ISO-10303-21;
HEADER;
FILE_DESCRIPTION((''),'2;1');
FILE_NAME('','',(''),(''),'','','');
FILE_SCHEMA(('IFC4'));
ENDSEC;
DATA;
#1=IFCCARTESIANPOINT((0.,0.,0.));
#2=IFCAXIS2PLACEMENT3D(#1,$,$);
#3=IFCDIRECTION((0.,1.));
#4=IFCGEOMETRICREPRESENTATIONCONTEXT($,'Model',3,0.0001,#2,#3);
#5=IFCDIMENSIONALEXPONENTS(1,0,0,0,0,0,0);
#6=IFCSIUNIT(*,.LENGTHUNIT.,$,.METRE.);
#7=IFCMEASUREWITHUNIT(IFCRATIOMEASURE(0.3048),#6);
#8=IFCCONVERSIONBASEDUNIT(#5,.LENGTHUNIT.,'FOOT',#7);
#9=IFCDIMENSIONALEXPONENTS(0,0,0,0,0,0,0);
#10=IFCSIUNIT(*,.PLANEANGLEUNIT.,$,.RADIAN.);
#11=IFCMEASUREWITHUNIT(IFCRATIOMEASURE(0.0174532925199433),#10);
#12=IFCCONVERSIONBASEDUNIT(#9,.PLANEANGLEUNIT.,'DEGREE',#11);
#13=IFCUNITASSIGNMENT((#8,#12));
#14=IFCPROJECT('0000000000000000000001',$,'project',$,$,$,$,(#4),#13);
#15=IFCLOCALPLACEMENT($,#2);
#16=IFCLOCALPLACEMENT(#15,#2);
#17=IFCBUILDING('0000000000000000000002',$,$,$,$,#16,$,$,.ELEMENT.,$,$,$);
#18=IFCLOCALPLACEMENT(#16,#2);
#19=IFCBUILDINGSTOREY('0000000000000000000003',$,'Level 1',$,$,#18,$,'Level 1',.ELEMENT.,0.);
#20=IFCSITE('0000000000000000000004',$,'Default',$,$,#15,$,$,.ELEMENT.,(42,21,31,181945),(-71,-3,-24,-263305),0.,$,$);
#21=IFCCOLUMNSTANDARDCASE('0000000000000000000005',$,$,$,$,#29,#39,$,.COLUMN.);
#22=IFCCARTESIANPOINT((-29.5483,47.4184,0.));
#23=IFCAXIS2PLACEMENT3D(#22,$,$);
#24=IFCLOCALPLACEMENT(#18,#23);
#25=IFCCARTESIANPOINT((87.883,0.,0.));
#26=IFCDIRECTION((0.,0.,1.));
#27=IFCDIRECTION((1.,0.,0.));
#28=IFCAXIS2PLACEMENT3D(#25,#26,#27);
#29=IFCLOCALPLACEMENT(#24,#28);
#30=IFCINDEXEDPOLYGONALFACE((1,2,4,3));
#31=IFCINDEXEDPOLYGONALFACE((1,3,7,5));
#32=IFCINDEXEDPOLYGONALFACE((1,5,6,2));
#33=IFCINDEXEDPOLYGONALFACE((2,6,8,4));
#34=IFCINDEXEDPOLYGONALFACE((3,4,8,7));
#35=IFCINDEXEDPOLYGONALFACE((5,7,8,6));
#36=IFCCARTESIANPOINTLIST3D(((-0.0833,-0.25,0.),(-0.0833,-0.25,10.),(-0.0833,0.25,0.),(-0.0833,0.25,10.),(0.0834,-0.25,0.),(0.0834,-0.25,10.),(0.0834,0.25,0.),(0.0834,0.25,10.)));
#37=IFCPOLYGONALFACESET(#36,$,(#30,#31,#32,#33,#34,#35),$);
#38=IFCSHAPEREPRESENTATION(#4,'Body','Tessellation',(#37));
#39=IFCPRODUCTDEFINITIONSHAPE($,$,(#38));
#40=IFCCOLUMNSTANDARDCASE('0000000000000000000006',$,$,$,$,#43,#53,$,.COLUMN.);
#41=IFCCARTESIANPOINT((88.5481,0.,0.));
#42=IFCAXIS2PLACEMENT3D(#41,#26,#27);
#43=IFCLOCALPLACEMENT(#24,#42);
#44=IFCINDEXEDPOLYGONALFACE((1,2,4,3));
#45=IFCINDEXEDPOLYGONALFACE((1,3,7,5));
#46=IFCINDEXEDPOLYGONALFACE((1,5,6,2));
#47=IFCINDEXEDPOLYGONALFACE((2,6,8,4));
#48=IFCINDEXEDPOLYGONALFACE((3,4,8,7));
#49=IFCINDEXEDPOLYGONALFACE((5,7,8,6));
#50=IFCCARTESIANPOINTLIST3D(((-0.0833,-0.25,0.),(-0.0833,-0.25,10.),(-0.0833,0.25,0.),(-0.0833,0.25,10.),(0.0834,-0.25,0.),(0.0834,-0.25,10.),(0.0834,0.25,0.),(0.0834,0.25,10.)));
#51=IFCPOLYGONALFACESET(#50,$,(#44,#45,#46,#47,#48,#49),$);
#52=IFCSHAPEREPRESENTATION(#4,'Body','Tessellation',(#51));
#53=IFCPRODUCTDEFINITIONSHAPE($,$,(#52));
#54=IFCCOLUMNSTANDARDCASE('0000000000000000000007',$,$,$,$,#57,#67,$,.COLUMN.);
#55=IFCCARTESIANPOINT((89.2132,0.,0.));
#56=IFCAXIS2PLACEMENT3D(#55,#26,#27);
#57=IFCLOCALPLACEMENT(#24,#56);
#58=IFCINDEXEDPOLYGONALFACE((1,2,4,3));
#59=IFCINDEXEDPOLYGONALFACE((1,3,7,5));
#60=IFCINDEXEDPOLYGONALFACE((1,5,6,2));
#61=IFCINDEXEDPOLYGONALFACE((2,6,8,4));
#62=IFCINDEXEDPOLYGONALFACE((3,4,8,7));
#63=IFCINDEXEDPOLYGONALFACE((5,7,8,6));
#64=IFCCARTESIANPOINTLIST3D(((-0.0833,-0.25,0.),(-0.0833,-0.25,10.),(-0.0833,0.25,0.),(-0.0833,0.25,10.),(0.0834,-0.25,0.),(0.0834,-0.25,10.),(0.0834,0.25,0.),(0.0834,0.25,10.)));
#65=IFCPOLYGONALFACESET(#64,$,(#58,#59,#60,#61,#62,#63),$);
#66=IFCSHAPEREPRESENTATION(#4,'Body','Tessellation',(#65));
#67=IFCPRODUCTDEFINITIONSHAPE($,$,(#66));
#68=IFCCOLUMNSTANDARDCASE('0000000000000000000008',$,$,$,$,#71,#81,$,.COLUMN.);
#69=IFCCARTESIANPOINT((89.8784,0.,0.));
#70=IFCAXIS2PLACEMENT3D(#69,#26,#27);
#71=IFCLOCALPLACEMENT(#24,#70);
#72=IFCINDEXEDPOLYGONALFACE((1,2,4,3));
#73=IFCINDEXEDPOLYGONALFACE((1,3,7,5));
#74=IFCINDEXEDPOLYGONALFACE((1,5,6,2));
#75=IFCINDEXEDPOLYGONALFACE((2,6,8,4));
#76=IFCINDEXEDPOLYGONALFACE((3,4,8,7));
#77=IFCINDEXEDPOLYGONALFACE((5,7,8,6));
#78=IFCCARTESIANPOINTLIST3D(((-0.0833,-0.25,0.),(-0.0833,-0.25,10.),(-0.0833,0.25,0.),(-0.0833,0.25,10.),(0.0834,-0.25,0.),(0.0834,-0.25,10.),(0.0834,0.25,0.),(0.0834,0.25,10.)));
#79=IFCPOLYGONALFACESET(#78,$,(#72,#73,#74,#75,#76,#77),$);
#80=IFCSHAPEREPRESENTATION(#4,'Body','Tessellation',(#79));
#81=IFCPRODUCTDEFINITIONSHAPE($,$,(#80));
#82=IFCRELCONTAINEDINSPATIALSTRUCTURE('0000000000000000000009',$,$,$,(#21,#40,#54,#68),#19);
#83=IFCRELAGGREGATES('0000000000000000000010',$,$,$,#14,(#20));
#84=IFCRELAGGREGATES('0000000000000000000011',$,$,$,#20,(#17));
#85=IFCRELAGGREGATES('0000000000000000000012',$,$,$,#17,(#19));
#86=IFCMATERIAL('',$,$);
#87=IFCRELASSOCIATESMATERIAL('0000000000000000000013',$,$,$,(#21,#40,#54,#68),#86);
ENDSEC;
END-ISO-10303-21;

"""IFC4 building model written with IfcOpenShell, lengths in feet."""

from ifc_helpers import new_model, entity, si_unit, converted_unit, direction, frame, origin, place, context, project, spatial, rectangle, extrude, material, element, save


model = new_model("IFC4")

# Units and contexts
model_context = context("Model", 3, precision=0.0001, world=origin(), true_north=direction((0.0, 1.0)))
ifc_project = project(units=[converted_unit("LENGTHUNIT", "FOOT", entity("IfcRatioMeasure", 0.3048), si_unit("LENGTHUNIT", "METRE"), dimensions=[1, 0, 0, 0, 0, 0, 0]), converted_unit("PLANEANGLEUNIT", "DEGREE", entity("IfcRatioMeasure", 0.0174532925199433), si_unit("PLANEANGLEUNIT", "RADIAN"), dimensions=[0, 0, 0, 0, 0, 0, 0])], contexts=[model_context])

# Site, building, storey
site_placement = place(None, origin())
site = spatial("IfcSite", under=ifc_project, at=site_placement, Name="Default", CompositionType="ELEMENT", RefLatitude=(42, 21, 31, 181945), RefLongitude=(-71, -3, -24, -263305), RefElevation=0.0)
building_placement = place(site_placement, origin())
building = spatial("IfcBuilding", under=site, at=building_placement, CompositionType="ELEMENT")
storey_placement = place(building_placement, origin())
storey = spatial("IfcBuildingStorey", under=building, at=storey_placement, Name="Level 1", LongName="Level 1", CompositionType="ELEMENT", Elevation=0.0)

# Columns
ifc_material = material(Name="")
placement = place(storey_placement, frame((-29.5483, 47.4184, 0.0)))
for number, where, z_axis, x_axis in (
    (1, (87.883, 0.0, 0.0), (0.0, 0.0, 1.0), (1.0, 0.0, 0.0)),
    (2, (88.5481, 0.0, 0.0), (0.0, 0.0, 1.0), (1.0, 0.0, 0.0)),
    (3, (89.2132, 0.0, 0.0), (0.0, 0.0, 1.0), (1.0, 0.0, 0.0)),
    (4, (89.8784, 0.0, 0.0), (0.0, 0.0, 1.0), (1.0, 0.0, 0.0)),
):
    element("IfcColumnStandardCase", number, at=place(placement, frame(where, z_axis=z_axis, x_axis=x_axis)), inside=storey, material=ifc_material, PredefinedType="COLUMN", context=model_context, shape_type="SweptSolid", body=[
        extrude(rectangle(XDim=0.1667, YDim=0.5), origin(), (0.0, 0.0, 1.0), 10.0),
    ])

save(model, "model.ifc")
